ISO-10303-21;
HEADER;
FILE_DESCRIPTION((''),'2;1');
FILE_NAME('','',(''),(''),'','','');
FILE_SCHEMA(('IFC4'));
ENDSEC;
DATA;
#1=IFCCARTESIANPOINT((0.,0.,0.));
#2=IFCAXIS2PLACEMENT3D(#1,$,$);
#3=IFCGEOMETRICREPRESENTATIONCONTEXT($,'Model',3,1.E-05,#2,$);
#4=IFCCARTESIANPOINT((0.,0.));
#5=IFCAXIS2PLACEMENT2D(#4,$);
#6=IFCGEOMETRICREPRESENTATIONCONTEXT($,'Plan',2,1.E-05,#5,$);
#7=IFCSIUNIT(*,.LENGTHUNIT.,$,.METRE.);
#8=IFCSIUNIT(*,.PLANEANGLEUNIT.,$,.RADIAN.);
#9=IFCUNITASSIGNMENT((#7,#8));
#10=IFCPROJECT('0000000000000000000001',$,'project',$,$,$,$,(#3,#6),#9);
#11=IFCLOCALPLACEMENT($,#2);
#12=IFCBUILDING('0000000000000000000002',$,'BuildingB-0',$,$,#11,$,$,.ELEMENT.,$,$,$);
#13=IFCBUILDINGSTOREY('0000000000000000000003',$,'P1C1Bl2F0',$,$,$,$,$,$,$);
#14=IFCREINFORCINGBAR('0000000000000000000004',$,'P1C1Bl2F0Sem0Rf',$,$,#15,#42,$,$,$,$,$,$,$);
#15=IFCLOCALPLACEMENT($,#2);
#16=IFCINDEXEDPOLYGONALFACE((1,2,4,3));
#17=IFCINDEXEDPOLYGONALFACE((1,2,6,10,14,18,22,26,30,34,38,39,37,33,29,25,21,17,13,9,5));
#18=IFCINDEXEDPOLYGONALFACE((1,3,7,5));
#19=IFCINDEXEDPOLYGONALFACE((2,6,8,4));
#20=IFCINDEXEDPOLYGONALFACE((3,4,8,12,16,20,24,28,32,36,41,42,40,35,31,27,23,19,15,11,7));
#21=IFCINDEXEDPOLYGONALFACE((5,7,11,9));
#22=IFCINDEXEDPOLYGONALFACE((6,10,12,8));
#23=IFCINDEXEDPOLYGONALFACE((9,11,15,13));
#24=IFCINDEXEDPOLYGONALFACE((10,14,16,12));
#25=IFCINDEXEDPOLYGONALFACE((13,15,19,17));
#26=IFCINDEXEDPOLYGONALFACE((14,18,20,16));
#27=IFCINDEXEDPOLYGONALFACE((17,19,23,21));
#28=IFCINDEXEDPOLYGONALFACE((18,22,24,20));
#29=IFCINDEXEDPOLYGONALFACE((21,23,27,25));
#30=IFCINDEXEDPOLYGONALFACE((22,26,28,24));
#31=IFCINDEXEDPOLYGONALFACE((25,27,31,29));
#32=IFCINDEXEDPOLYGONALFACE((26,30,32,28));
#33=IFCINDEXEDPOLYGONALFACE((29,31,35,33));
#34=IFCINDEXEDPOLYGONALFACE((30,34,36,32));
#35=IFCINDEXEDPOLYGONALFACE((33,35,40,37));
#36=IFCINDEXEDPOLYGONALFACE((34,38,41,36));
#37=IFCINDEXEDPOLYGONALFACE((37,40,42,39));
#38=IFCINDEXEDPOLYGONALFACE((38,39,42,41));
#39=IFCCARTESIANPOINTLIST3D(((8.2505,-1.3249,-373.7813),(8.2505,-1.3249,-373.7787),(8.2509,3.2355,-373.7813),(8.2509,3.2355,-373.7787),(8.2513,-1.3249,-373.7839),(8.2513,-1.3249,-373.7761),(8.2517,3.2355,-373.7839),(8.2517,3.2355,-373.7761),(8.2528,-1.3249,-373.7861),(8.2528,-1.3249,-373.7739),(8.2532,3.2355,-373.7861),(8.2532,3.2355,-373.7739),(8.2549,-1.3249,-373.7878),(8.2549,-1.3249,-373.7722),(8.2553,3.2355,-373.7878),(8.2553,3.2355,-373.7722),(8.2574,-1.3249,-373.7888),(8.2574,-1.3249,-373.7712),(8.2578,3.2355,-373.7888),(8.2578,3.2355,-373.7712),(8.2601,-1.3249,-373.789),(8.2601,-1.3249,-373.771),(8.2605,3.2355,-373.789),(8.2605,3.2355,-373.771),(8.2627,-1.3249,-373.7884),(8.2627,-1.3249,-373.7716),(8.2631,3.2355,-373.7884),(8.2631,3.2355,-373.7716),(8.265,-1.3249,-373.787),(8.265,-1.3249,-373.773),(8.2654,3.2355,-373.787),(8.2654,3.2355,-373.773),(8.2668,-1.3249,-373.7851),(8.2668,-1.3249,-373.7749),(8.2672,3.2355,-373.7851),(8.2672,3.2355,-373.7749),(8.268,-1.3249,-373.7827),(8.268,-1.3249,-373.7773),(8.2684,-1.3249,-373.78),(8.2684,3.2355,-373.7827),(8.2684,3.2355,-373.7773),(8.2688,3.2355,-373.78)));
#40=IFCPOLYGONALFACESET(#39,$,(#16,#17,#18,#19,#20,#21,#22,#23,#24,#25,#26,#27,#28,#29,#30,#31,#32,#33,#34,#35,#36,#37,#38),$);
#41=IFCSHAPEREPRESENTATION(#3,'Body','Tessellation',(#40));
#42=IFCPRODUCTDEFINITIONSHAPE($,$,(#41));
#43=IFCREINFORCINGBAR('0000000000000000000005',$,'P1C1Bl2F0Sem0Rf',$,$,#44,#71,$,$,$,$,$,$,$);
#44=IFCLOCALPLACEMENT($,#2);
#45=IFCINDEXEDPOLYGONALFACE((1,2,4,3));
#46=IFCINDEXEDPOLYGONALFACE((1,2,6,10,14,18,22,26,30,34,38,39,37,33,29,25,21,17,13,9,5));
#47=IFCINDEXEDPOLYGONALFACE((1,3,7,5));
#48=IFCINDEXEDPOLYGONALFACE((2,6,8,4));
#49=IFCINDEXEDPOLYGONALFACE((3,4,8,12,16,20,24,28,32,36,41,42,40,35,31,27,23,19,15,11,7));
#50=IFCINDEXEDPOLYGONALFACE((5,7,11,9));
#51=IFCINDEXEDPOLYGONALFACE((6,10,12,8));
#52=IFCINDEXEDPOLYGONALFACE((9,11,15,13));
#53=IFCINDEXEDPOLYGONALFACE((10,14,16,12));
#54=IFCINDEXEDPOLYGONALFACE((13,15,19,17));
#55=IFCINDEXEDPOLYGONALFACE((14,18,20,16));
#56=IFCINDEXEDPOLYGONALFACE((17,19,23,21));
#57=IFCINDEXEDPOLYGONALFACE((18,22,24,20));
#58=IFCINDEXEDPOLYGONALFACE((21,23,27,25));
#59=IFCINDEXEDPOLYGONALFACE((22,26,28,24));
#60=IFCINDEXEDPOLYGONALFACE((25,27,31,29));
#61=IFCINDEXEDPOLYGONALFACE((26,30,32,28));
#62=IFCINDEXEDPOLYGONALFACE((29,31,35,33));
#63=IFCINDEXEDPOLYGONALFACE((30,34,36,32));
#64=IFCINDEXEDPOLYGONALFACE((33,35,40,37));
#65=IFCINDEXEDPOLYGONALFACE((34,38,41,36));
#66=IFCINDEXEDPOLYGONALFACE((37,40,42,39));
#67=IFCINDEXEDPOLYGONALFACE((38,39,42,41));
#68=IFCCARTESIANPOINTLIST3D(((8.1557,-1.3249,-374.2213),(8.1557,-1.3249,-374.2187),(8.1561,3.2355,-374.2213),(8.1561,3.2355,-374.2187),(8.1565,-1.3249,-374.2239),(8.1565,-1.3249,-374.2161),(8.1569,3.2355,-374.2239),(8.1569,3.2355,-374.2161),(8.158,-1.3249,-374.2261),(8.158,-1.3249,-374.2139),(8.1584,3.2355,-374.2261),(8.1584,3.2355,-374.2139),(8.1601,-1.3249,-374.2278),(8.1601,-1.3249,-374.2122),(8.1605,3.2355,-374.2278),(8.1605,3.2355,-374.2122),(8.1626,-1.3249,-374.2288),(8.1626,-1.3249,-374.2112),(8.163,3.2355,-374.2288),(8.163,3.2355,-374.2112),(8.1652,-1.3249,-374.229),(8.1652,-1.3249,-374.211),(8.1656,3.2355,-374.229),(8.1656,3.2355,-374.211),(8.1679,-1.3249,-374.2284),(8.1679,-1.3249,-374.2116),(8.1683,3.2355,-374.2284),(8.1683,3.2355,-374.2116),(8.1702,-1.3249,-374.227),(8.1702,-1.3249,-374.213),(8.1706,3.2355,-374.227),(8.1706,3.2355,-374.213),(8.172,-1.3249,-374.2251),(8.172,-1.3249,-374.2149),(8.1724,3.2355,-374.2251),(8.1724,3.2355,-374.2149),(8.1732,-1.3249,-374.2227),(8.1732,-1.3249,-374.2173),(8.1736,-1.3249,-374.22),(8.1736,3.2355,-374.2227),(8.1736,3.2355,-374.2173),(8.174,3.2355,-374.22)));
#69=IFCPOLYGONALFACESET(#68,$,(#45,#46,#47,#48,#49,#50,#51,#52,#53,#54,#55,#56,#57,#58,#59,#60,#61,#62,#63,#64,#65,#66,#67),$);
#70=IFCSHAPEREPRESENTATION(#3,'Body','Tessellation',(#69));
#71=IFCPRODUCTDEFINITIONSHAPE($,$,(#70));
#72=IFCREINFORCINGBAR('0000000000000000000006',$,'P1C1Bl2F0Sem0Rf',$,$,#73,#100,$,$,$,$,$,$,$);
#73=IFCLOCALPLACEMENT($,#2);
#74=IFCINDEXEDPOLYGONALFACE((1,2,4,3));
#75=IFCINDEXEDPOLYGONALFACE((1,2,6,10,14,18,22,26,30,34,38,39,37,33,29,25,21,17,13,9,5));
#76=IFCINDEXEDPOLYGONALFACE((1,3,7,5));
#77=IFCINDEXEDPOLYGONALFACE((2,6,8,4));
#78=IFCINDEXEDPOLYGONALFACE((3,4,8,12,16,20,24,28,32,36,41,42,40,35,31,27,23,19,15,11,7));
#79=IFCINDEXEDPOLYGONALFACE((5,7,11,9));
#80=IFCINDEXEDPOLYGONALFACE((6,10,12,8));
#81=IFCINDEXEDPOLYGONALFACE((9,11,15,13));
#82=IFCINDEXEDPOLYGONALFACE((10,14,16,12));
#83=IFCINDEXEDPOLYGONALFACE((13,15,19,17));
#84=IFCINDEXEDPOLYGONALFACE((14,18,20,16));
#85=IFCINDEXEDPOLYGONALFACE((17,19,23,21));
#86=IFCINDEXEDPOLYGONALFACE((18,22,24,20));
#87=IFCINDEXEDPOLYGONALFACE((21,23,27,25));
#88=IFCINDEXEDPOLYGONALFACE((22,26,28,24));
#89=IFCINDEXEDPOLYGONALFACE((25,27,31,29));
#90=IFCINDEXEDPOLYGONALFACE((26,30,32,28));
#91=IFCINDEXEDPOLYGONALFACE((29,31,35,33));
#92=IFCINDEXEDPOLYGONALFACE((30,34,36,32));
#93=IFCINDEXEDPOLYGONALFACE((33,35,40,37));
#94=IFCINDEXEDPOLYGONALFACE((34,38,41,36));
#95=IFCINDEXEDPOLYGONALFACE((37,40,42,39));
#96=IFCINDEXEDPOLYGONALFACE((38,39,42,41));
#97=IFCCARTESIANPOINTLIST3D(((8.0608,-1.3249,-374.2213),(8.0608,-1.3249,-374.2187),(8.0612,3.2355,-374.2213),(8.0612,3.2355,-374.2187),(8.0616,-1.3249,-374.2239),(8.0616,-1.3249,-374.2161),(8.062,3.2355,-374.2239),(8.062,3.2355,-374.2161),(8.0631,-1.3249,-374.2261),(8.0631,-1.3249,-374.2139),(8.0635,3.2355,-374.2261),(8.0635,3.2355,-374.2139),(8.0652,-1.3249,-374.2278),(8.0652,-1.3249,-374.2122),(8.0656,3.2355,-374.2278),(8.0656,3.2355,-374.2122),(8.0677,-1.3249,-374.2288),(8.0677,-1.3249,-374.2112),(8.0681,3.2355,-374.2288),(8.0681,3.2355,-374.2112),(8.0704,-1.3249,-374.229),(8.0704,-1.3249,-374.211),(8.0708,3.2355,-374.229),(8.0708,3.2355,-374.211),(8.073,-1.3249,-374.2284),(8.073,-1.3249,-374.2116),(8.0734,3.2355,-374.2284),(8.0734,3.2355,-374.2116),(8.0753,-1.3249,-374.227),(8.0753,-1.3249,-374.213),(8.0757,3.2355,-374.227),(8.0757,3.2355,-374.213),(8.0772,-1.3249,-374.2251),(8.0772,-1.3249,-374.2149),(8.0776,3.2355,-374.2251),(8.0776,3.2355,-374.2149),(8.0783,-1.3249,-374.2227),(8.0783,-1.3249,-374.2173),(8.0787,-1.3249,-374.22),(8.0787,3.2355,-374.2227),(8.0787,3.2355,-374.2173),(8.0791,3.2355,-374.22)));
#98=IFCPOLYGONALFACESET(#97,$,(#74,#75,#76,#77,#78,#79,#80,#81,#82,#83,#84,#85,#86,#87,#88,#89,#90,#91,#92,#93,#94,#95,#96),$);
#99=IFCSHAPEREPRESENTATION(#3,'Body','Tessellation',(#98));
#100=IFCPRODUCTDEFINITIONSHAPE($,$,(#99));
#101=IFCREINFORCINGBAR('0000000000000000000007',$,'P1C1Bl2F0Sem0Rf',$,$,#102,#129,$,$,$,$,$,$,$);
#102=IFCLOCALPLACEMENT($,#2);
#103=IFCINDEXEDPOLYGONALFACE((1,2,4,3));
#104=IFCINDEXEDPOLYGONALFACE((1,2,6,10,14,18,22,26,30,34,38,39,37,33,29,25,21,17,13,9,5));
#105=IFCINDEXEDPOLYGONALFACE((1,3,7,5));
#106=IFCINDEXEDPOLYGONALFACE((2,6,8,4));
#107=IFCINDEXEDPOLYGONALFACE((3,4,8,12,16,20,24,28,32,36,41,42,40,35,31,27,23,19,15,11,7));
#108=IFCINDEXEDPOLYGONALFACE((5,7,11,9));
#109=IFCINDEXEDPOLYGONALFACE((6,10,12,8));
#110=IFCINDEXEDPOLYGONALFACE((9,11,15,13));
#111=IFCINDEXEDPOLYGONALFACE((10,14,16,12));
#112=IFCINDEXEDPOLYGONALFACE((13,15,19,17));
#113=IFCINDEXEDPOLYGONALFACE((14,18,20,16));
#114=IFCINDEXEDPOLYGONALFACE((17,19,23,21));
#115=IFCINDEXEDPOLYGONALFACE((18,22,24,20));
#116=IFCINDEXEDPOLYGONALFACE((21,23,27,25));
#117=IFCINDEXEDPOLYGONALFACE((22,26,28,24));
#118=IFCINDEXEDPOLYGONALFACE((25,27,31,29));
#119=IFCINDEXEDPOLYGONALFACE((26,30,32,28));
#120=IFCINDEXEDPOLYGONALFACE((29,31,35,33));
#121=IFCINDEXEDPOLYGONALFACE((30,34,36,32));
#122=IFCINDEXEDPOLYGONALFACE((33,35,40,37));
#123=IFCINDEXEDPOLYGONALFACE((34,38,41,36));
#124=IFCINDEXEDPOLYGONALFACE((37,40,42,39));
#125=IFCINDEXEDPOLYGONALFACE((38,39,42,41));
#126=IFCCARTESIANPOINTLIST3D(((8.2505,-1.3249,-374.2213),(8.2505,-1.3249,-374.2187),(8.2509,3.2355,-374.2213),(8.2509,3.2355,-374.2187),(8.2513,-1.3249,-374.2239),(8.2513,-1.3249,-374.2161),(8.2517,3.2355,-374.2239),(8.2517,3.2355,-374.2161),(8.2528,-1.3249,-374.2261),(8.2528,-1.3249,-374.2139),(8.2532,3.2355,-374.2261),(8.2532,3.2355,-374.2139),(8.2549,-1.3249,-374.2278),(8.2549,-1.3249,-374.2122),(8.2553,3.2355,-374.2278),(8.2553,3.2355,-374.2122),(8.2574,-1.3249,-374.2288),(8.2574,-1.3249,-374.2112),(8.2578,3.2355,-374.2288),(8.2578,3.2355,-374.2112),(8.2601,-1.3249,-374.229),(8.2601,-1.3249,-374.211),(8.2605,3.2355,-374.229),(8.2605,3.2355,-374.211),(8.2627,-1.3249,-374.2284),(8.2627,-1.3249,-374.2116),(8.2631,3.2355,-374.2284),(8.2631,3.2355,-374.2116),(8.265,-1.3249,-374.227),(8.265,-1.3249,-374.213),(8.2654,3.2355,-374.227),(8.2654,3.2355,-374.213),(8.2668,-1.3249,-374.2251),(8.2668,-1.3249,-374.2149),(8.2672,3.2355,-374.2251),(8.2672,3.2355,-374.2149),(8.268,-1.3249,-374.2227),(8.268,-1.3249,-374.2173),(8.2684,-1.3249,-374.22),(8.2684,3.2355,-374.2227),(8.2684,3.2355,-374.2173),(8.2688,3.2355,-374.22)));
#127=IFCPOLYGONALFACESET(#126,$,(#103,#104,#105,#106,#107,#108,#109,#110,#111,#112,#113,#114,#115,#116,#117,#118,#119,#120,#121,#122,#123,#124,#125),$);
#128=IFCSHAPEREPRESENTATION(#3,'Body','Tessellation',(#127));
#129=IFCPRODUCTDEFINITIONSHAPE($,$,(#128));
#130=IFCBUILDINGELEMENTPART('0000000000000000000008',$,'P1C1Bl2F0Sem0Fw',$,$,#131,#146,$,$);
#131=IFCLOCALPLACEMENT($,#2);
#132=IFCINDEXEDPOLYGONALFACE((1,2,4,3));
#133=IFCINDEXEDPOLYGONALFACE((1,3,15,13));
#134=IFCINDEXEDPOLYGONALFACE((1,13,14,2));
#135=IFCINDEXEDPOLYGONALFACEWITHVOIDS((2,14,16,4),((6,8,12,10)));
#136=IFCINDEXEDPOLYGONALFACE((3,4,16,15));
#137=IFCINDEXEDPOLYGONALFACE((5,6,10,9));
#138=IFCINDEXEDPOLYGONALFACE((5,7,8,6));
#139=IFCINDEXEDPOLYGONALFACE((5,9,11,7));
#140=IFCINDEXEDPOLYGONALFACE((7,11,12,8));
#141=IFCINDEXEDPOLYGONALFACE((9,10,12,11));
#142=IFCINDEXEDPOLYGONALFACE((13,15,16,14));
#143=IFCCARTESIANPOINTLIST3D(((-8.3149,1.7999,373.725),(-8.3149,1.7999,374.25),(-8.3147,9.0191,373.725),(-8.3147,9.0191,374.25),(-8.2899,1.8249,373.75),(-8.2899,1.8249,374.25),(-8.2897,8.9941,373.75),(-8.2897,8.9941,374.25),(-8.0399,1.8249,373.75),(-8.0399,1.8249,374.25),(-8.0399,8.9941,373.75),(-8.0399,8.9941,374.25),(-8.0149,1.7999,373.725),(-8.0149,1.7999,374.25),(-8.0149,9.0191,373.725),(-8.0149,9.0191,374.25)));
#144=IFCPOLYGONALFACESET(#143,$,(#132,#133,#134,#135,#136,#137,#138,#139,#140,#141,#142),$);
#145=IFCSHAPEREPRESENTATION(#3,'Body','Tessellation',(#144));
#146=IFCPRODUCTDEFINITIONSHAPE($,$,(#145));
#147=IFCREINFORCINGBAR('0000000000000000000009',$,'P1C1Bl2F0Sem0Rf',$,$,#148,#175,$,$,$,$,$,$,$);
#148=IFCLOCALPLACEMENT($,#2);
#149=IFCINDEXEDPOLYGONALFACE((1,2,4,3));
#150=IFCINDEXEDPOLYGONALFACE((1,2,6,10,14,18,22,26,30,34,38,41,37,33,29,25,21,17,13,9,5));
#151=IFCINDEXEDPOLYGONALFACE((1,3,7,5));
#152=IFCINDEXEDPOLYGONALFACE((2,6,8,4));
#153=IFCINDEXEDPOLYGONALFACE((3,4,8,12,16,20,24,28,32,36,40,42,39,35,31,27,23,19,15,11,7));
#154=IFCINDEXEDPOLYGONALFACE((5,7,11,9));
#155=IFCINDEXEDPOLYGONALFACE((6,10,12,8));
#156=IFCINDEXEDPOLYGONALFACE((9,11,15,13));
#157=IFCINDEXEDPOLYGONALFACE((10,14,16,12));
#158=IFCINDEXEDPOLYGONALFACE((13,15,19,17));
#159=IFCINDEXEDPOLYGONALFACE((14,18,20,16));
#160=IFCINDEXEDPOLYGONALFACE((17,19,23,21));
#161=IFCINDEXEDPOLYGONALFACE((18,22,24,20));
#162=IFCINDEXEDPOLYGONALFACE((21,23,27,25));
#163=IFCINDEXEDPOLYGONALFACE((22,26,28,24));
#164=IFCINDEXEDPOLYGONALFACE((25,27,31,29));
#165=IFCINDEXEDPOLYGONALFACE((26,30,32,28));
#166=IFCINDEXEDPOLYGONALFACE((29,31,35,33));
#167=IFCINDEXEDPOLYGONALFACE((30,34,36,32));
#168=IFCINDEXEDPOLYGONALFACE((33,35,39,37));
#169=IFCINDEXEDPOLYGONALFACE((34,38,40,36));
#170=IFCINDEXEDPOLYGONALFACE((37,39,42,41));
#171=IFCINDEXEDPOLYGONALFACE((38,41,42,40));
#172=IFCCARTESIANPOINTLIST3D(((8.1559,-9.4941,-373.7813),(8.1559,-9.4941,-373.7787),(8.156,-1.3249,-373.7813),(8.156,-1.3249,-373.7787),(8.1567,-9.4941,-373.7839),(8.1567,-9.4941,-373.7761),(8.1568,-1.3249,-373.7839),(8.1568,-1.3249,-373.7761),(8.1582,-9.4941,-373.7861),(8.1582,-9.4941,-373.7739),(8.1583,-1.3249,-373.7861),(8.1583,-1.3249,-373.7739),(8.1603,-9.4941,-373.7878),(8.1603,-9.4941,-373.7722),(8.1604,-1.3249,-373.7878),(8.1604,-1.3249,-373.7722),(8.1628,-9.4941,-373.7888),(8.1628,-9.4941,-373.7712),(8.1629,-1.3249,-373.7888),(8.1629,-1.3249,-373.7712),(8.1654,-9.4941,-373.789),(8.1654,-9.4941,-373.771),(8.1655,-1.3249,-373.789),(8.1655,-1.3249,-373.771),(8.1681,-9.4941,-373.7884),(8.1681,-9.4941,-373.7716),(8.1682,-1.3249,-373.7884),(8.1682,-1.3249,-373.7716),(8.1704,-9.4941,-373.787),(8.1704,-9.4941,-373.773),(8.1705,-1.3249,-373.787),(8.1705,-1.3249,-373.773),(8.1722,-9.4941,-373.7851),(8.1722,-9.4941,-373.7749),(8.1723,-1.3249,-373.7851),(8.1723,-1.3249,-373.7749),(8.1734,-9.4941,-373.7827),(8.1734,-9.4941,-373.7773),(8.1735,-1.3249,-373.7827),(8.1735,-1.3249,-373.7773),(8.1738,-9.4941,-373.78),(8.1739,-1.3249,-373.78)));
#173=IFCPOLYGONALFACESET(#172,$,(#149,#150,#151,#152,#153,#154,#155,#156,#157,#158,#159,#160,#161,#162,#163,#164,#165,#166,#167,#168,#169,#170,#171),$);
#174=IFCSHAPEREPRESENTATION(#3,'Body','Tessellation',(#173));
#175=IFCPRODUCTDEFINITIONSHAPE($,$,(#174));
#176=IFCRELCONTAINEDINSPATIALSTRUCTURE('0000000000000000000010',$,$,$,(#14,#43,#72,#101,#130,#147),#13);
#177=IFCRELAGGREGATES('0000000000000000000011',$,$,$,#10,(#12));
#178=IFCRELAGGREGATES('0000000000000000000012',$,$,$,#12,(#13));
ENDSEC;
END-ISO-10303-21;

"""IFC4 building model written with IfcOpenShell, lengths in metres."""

from ifc_helpers import new_model, entity, si_unit, origin, origin_2d, place, context, project, spatial, polyline, outline, extrude, element, save


model = new_model("IFC4")

# Units and contexts
model_context = context("Model", 3, precision=1e-05, world=origin())
plan_context = context("Plan", 2, precision=1e-05, world=origin_2d())
ifc_project = project(units=[si_unit("LENGTHUNIT", "METRE"), si_unit("PLANEANGLEUNIT", "RADIAN")], contexts=[model_context, plan_context])

# Building, storey
building_placement = place(None, origin())
building = spatial("IfcBuilding", under=ifc_project, at=building_placement, Name="BuildingB-0", CompositionType="ELEMENT")
storey = spatial("IfcBuildingStorey", under=building, Name="P1C1Bl2F0")

# Reinforcing bars
element("IfcReinforcingBar", 1, inside=storey, Name="P1C1Bl2F0Sem0Rf", context=model_context, shape_type="SweptSolid", body=[
    entity("IfcSurfaceCurveSweptAreaSolid", entity("IfcCircleProfileDef", "AREA", None, None, 0.009), None, entity("IfcPolyline", [entity("IfcCartesianPoint", [-8.2598, -3.2355, 373.78]), entity("IfcCartesianPoint", [-8.2594, 1.3249, 373.78])]), None, None, entity("IfcPlane", entity("IfcAxis2Placement3D", entity("IfcCartesianPoint", [-8.2598, -3.2355, 373.78]), entity("IfcDirection", [0.0, 0.0, 1.0]), entity("IfcDirection", [1.0, 0.0, 0.0])))),
])
element("IfcReinforcingBar", 2, inside=storey, Name="P1C1Bl2F0Sem0Rf", context=model_context, shape_type="SweptSolid", body=[
    entity("IfcSurfaceCurveSweptAreaSolid", entity("IfcCircleProfileDef", "AREA", None, None, 0.009), None, entity("IfcPolyline", [entity("IfcCartesianPoint", [-8.165, -3.2355, 374.22]), entity("IfcCartesianPoint", [-8.1646, 1.3249, 374.22])]), None, None, entity("IfcPlane", entity("IfcAxis2Placement3D", entity("IfcCartesianPoint", [-8.165, -3.2355, 374.22]), entity("IfcDirection", [0.0, 0.0, 1.0]), entity("IfcDirection", [1.0, 0.0, 0.0])))),
])
element("IfcReinforcingBar", 3, inside=storey, Name="P1C1Bl2F0Sem0Rf", context=model_context, shape_type="SweptSolid", body=[
    entity("IfcSurfaceCurveSweptAreaSolid", entity("IfcCircleProfileDef", "AREA", None, None, 0.009), None, entity("IfcPolyline", [entity("IfcCartesianPoint", [-8.0701, -3.2355, 374.22]), entity("IfcCartesianPoint", [-8.0697, 1.3249, 374.22])]), None, None, entity("IfcPlane", entity("IfcAxis2Placement3D", entity("IfcCartesianPoint", [-8.0701, -3.2355, 374.22]), entity("IfcDirection", [0.0, 0.0, 1.0]), entity("IfcDirection", [1.0, 0.0, 0.0])))),
])
element("IfcReinforcingBar", 4, inside=storey, Name="P1C1Bl2F0Sem0Rf", context=model_context, shape_type="SweptSolid", body=[
    entity("IfcSurfaceCurveSweptAreaSolid", entity("IfcCircleProfileDef", "AREA", None, None, 0.009), None, entity("IfcPolyline", [entity("IfcCartesianPoint", [-8.2598, -3.2355, 374.22]), entity("IfcCartesianPoint", [-8.2594, 1.3249, 374.22])]), None, None, entity("IfcPlane", entity("IfcAxis2Placement3D", entity("IfcCartesianPoint", [-8.2598, -3.2355, 374.22]), entity("IfcDirection", [0.0, 0.0, 1.0]), entity("IfcDirection", [1.0, 0.0, 0.0])))),
])

# Building element part, opening
building_element_part_1 = element("IfcBuildingElementPart", 5, inside=storey, Name="P1C1Bl2F0Sem0Fw", context=model_context, shape_type="SweptSolid", body=[
    extrude(outline(polyline([(-8.3149, 1.7999, 373.725), (-8.0149, 1.7999, 373.725), (-8.0149, 9.0191, 373.725), (-8.3147, 9.0191, 373.725), (-8.3149, 1.7999, 373.725)])), None, (0.0, 0.0, 1.0), 0.525),
])
element("IfcOpeningElement", 6, inside=storey, cuts=building_element_part_1, context=model_context, shape_type="SweptSolid", body=[
    extrude(outline(polyline([(-8.2899, 1.8249, 373.75), (-8.0399, 1.8249, 373.75), (-8.0399, 8.9941, 373.75), (-8.2897, 8.9941, 373.75), (-8.2899, 1.8249, 373.75)])), None, (0.0, 0.0, 1.0), 0.5),
])

# Reinforcing bar
element("IfcReinforcingBar", 7, inside=storey, Name="P1C1Bl2F0Sem0Rf", context=model_context, shape_type="SweptSolid", body=[
    entity("IfcSurfaceCurveSweptAreaSolid", entity("IfcCircleProfileDef", "AREA", None, None, 0.009), None, entity("IfcPolyline", [entity("IfcCartesianPoint", [-8.1649, 1.3249, 373.78]), entity("IfcCartesianPoint", [-8.1648, 9.4941, 373.78])]), None, None, entity("IfcPlane", entity("IfcAxis2Placement3D", entity("IfcCartesianPoint", [-8.1649, 1.3249, 373.78]), entity("IfcDirection", [0.0, 0.0, 1.0]), entity("IfcDirection", [1.0, 0.0, 0.0])))),
])

save(model, "model.ifc")
